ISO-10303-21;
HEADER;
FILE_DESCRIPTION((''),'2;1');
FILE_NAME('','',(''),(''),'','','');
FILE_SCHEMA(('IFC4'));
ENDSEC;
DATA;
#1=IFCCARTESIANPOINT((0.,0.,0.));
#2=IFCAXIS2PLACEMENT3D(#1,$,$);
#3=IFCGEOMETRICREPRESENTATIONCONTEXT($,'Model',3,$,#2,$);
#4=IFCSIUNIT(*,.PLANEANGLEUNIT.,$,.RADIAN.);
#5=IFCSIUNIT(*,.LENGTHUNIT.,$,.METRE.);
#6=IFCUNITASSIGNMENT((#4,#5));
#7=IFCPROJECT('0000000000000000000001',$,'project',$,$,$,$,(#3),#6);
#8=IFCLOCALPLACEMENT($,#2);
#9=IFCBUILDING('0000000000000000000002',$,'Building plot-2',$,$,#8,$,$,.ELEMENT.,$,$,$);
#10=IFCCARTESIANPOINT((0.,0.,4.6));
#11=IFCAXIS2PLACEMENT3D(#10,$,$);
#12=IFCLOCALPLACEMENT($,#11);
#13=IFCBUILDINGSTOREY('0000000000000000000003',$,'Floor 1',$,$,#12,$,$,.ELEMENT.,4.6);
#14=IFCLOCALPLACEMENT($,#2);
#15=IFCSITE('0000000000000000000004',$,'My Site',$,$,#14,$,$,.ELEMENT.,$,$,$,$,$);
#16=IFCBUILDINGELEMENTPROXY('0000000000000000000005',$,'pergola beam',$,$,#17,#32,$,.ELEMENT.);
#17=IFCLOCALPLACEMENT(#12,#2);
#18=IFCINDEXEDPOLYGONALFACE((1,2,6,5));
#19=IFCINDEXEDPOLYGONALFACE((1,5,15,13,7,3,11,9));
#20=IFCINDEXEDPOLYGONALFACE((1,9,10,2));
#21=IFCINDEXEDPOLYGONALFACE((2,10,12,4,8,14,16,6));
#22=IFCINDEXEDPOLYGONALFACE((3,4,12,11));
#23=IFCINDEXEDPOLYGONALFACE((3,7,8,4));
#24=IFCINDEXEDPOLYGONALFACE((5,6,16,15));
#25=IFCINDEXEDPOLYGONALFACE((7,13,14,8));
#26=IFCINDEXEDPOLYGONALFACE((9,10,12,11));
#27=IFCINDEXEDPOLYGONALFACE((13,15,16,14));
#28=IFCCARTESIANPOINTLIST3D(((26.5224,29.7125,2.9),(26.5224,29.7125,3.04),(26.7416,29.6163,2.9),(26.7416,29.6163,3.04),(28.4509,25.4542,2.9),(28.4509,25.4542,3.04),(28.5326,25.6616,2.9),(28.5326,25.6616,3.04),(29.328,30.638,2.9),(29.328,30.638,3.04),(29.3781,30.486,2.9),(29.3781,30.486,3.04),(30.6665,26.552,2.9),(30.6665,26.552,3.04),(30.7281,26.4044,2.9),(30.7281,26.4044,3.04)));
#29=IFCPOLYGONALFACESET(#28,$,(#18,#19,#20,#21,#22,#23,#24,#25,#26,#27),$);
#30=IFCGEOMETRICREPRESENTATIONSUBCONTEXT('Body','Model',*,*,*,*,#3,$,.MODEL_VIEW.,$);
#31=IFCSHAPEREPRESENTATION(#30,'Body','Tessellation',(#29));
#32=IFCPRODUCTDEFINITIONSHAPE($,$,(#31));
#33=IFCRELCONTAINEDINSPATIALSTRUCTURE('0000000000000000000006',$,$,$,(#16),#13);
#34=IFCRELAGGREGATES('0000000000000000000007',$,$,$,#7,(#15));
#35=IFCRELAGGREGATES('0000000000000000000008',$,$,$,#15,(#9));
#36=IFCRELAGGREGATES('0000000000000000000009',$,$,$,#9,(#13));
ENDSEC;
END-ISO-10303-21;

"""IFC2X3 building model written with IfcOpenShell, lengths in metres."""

from ifc_helpers import new_model, entity, si_unit, frame, origin, place, context, subcontext, project, spatial, element, save


model = new_model("IFC2X3")

# Units and contexts
model_context = context("Model", 3, world=origin())
body_context = subcontext(model_context, "Body", "Model", "MODEL_VIEW")
ifc_project = project(units=[si_unit("PLANEANGLEUNIT", "RADIAN"), si_unit("LENGTHUNIT", "METRE")], contexts=[model_context])

# Site, building, storey
site_placement = place(None, origin())
site = spatial("IfcSite", under=ifc_project, at=site_placement, Name="My Site", CompositionType="ELEMENT")
building_placement = place(None, origin())
building = spatial("IfcBuilding", under=site, at=building_placement, Name="Building plot-2", CompositionType="ELEMENT")
storey_placement = place(None, frame((0.0, 0.0, 4.6)))
storey = spatial("IfcBuildingStorey", under=building, at=storey_placement, Name="Floor 1", CompositionType="ELEMENT", Elevation=4.6)

# Building element proxy
proxy_1_placement = place(storey_placement, frame((0.0, 0.0, 3.6)))
axis2_placement3_d_1 = entity("IfcAxis2Placement3D", entity("IfcCartesianPoint", [0.0, 0.0, 0.0]))
element("IfcBuildingElementProxy", 1, at=proxy_1_placement, inside=storey, Name="pergola beam", CompositionType="ELEMENT", context=body_context, shape_type="SweptSolid", held_by="IfcProductRepresentation", body=[
    entity("IfcSurfaceCurveSweptAreaSolid", entity("IfcArbitraryClosedProfileDef", "AREA", None, entity("IfcPolyline", [entity("IfcCartesianPoint", [-0.7, -0.08]), entity("IfcCartesianPoint", [-0.7, 0.08]), entity("IfcCartesianPoint", [-0.56, 0.08]), entity("IfcCartesianPoint", [-0.56, -0.08]), entity("IfcCartesianPoint", [-0.7, -0.08])])), axis2_placement3_d_1, entity("IfcPolyline", [entity("IfcCartesianPoint", [29.3531, 30.562]), entity("IfcCartesianPoint", [26.632, 29.6644]), entity("IfcCartesianPoint", [28.4917, 25.5579]), entity("IfcCartesianPoint", [30.6973, 26.4782])]), 0.0, 1.0, entity("IfcPlane", axis2_placement3_d_1)),
])

save(model, "model.ifc")
